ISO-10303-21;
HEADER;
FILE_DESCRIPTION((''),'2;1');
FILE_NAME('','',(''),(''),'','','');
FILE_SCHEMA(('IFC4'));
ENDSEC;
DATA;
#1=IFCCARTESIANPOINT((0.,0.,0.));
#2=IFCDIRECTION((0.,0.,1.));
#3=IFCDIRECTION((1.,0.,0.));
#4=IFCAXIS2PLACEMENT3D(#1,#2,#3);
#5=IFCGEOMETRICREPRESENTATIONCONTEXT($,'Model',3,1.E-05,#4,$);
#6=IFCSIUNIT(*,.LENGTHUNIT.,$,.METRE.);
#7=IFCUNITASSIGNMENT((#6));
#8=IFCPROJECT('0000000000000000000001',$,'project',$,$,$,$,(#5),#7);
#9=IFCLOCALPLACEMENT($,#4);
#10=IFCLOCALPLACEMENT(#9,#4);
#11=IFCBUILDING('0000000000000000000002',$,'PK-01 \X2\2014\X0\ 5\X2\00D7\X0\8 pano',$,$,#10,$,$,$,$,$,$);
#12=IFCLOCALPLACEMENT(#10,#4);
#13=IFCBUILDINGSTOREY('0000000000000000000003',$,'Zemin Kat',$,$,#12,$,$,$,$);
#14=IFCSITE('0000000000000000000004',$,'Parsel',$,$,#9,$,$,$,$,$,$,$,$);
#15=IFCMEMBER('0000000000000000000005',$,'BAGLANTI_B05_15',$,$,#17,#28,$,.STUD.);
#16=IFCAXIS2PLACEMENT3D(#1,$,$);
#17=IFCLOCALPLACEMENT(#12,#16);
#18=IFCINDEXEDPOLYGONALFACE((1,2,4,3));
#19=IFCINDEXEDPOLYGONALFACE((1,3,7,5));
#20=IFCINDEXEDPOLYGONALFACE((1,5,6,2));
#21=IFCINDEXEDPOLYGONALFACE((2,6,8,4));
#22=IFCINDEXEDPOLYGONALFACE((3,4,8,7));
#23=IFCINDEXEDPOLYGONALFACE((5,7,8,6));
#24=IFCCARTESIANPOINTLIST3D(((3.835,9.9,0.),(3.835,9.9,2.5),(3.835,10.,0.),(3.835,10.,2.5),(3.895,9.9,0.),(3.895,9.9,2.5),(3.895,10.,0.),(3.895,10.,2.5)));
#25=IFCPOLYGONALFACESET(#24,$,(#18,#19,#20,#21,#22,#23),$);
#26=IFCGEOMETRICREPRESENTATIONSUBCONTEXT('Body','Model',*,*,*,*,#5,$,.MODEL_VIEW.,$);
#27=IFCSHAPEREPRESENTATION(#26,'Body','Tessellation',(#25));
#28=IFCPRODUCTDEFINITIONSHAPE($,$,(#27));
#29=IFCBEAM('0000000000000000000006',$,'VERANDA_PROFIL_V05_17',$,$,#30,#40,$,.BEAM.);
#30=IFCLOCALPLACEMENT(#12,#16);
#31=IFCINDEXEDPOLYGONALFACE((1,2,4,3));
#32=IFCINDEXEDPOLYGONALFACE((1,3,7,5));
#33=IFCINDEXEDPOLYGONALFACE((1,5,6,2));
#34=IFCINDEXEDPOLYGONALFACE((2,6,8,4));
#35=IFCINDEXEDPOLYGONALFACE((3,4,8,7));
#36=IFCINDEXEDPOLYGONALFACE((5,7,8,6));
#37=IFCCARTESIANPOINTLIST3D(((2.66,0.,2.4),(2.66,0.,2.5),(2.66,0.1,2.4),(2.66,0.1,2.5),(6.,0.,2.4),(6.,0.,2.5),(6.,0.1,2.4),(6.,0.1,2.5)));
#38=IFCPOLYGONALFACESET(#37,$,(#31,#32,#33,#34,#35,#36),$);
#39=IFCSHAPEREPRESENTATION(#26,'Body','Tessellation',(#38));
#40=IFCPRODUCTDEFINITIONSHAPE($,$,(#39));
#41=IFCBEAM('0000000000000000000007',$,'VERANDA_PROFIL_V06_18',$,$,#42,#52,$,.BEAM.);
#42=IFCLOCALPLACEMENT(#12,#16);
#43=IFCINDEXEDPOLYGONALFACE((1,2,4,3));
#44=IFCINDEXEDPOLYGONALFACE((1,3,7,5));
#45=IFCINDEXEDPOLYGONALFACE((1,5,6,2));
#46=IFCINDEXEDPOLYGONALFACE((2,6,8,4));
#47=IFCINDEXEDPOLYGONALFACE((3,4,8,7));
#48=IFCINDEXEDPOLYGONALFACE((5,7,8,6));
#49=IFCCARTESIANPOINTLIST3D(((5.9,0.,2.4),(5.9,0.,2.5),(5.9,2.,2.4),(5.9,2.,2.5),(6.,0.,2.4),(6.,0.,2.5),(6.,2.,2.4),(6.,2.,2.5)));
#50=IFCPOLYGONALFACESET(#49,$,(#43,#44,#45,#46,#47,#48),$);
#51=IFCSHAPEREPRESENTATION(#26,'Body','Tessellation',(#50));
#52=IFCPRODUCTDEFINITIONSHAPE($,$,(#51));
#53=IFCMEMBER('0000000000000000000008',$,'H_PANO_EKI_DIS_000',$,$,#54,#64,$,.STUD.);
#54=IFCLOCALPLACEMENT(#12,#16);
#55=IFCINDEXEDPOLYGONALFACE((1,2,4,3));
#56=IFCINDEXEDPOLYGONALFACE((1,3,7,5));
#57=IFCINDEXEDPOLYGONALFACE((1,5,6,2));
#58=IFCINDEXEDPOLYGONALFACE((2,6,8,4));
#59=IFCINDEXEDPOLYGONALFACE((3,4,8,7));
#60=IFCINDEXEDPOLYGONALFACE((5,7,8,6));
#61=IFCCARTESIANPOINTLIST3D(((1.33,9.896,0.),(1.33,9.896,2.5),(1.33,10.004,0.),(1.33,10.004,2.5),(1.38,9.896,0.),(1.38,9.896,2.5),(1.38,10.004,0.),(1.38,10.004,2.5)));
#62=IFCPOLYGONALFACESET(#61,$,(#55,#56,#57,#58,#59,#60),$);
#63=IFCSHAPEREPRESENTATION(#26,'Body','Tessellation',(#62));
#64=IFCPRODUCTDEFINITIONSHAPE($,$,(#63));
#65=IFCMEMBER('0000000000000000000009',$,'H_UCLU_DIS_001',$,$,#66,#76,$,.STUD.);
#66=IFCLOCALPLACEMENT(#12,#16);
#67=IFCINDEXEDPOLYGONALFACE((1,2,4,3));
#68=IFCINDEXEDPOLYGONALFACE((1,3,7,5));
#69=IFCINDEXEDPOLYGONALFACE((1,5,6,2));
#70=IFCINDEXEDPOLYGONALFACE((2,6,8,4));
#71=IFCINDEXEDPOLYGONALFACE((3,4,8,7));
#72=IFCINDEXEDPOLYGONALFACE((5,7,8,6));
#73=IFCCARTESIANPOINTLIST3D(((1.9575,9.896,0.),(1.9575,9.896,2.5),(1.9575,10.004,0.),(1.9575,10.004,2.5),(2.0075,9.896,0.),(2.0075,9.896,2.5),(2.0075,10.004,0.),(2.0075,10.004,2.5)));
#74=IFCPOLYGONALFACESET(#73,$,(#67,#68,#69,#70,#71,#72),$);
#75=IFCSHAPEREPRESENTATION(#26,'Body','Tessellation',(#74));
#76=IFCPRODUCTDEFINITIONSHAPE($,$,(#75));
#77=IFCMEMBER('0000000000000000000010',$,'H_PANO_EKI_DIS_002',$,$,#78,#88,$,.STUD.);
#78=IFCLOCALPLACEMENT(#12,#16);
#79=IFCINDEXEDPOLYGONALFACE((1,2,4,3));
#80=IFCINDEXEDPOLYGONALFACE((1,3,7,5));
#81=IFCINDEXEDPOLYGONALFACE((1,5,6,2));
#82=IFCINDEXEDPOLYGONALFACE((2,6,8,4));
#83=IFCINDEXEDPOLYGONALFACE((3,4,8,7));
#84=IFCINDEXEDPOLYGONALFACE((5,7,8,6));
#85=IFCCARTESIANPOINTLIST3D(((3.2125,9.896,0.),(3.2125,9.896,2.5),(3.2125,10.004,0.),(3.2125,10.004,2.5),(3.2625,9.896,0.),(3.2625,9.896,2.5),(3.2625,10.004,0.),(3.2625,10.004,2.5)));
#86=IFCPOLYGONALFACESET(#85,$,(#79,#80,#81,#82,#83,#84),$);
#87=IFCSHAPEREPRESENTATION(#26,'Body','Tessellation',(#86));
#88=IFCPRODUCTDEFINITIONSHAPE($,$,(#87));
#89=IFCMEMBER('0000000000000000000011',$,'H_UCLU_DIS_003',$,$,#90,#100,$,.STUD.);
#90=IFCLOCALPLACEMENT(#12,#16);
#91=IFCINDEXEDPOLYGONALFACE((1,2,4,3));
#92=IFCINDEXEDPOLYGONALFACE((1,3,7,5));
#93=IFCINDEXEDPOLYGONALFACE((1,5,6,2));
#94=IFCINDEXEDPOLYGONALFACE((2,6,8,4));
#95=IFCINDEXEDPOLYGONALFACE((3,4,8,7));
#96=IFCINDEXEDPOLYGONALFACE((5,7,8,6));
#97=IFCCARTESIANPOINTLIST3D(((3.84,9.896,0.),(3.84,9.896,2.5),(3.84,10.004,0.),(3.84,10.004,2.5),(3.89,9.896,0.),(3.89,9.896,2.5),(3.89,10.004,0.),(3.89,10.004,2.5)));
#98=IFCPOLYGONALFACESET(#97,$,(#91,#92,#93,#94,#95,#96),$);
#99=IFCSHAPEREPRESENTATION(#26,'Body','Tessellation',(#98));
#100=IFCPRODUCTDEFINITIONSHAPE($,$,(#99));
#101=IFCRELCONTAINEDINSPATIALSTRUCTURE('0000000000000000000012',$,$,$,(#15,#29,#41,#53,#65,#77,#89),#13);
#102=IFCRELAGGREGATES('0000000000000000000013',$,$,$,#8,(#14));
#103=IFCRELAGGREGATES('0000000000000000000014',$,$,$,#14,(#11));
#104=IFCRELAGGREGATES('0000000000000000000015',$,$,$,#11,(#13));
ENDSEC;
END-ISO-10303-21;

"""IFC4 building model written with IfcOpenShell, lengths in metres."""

from ifc_helpers import new_model, si_unit, frame, origin_with_axes, place, context, subcontext, project, spatial, line, indexed_curve, outline, extrude, element, save


model = new_model("IFC4")

# Units and contexts
model_context = context("Model", 3, precision=1e-05, world=origin_with_axes())
body_context = subcontext(model_context, "Body", "Model", "MODEL_VIEW")
ifc_project = project(units=[si_unit("LENGTHUNIT", "METRE")], contexts=[model_context])

# Site, building, storey
site_placement = place(None, origin_with_axes())
site = spatial("IfcSite", under=ifc_project, at=site_placement, Name="Parsel")
building_placement = place(site_placement, origin_with_axes())
building = spatial("IfcBuilding", under=site, at=building_placement, Name="PK-01 — 5×8 pano")
storey_placement = place(building_placement, origin_with_axes())
storey = spatial("IfcBuildingStorey", under=building, at=storey_placement, Name="Zemin Kat")

# Member
member_1_placement = place(storey_placement, origin_with_axes())
element("IfcMember", 1, at=member_1_placement, inside=storey, Name="BAGLANTI_B05_15", PredefinedType="STUD", context=body_context, shape_type="SweptSolid", body=[
    extrude(outline(indexed_curve([(3.835, 9.9), (3.895, 9.9), (3.895, 10.0), (3.835, 10.0)], segments=[line(1, 2, 3, 4, 1)])), origin_with_axes(), (0.0, 0.0, 1.0), 2.5),
])

# Beams
beam_1_placement = place(storey_placement, origin_with_axes())
element("IfcBeam", 2, at=beam_1_placement, inside=storey, Name="VERANDA_PROFIL_V05_17", PredefinedType="BEAM", context=body_context, shape_type="SweptSolid", body=[
    extrude(outline(indexed_curve([(2.66, 0.0), (6.0, 0.0), (6.0, 0.1), (2.66, 0.1)], segments=[line(1, 2, 3, 4, 1)])), frame((0.0, 0.0, 2.4), z_axis=(0.0, 0.0, 1.0), x_axis=(1.0, 0.0, 0.0)), (0.0, 0.0, 1.0), 0.1),
])
beam_2_placement = place(storey_placement, origin_with_axes())
element("IfcBeam", 3, at=beam_2_placement, inside=storey, Name="VERANDA_PROFIL_V06_18", PredefinedType="BEAM", context=body_context, shape_type="SweptSolid", body=[
    extrude(outline(indexed_curve([(5.9, 0.0), (6.0, 0.0), (6.0, 2.0), (5.9, 2.0)], segments=[line(1, 2, 3, 4, 1)])), frame((0.0, 0.0, 2.4), z_axis=(0.0, 0.0, 1.0), x_axis=(1.0, 0.0, 0.0)), (0.0, 0.0, 1.0), 0.1),
])

# Members
member_2_placement = place(storey_placement, origin_with_axes())
element("IfcMember", 4, at=member_2_placement, inside=storey, Name="H_PANO_EKI_DIS_000", PredefinedType="STUD", context=body_context, shape_type="SweptSolid", body=[
    extrude(outline(indexed_curve([(1.33, 9.896), (1.38, 9.896), (1.38, 10.004), (1.33, 10.004)], segments=[line(1, 2, 3, 4, 1)])), origin_with_axes(), (0.0, 0.0, 1.0), 2.5),
])
member_3_placement = place(storey_placement, origin_with_axes())
element("IfcMember", 5, at=member_3_placement, inside=storey, Name="H_UCLU_DIS_001", PredefinedType="STUD", context=body_context, shape_type="SweptSolid", body=[
    extrude(outline(indexed_curve([(1.9575, 9.896), (2.0075, 9.896), (2.0075, 10.004), (1.9575, 10.004)], segments=[line(1, 2, 3, 4, 1)])), origin_with_axes(), (0.0, 0.0, 1.0), 2.5),
])
member_4_placement = place(storey_placement, origin_with_axes())
element("IfcMember", 6, at=member_4_placement, inside=storey, Name="H_PANO_EKI_DIS_002", PredefinedType="STUD", context=body_context, shape_type="SweptSolid", body=[
    extrude(outline(indexed_curve([(3.2125, 9.896), (3.2625, 9.896), (3.2625, 10.004), (3.2125, 10.004)], segments=[line(1, 2, 3, 4, 1)])), origin_with_axes(), (0.0, 0.0, 1.0), 2.5),
])
member_5_placement = place(storey_placement, origin_with_axes())
element("IfcMember", 7, at=member_5_placement, inside=storey, Name="H_UCLU_DIS_003", PredefinedType="STUD", context=body_context, shape_type="SweptSolid", body=[
    extrude(outline(indexed_curve([(3.84, 9.896), (3.89, 9.896), (3.89, 10.004), (3.84, 10.004)], segments=[line(1, 2, 3, 4, 1)])), origin_with_axes(), (0.0, 0.0, 1.0), 2.5),
])

save(model, "model.ifc")
